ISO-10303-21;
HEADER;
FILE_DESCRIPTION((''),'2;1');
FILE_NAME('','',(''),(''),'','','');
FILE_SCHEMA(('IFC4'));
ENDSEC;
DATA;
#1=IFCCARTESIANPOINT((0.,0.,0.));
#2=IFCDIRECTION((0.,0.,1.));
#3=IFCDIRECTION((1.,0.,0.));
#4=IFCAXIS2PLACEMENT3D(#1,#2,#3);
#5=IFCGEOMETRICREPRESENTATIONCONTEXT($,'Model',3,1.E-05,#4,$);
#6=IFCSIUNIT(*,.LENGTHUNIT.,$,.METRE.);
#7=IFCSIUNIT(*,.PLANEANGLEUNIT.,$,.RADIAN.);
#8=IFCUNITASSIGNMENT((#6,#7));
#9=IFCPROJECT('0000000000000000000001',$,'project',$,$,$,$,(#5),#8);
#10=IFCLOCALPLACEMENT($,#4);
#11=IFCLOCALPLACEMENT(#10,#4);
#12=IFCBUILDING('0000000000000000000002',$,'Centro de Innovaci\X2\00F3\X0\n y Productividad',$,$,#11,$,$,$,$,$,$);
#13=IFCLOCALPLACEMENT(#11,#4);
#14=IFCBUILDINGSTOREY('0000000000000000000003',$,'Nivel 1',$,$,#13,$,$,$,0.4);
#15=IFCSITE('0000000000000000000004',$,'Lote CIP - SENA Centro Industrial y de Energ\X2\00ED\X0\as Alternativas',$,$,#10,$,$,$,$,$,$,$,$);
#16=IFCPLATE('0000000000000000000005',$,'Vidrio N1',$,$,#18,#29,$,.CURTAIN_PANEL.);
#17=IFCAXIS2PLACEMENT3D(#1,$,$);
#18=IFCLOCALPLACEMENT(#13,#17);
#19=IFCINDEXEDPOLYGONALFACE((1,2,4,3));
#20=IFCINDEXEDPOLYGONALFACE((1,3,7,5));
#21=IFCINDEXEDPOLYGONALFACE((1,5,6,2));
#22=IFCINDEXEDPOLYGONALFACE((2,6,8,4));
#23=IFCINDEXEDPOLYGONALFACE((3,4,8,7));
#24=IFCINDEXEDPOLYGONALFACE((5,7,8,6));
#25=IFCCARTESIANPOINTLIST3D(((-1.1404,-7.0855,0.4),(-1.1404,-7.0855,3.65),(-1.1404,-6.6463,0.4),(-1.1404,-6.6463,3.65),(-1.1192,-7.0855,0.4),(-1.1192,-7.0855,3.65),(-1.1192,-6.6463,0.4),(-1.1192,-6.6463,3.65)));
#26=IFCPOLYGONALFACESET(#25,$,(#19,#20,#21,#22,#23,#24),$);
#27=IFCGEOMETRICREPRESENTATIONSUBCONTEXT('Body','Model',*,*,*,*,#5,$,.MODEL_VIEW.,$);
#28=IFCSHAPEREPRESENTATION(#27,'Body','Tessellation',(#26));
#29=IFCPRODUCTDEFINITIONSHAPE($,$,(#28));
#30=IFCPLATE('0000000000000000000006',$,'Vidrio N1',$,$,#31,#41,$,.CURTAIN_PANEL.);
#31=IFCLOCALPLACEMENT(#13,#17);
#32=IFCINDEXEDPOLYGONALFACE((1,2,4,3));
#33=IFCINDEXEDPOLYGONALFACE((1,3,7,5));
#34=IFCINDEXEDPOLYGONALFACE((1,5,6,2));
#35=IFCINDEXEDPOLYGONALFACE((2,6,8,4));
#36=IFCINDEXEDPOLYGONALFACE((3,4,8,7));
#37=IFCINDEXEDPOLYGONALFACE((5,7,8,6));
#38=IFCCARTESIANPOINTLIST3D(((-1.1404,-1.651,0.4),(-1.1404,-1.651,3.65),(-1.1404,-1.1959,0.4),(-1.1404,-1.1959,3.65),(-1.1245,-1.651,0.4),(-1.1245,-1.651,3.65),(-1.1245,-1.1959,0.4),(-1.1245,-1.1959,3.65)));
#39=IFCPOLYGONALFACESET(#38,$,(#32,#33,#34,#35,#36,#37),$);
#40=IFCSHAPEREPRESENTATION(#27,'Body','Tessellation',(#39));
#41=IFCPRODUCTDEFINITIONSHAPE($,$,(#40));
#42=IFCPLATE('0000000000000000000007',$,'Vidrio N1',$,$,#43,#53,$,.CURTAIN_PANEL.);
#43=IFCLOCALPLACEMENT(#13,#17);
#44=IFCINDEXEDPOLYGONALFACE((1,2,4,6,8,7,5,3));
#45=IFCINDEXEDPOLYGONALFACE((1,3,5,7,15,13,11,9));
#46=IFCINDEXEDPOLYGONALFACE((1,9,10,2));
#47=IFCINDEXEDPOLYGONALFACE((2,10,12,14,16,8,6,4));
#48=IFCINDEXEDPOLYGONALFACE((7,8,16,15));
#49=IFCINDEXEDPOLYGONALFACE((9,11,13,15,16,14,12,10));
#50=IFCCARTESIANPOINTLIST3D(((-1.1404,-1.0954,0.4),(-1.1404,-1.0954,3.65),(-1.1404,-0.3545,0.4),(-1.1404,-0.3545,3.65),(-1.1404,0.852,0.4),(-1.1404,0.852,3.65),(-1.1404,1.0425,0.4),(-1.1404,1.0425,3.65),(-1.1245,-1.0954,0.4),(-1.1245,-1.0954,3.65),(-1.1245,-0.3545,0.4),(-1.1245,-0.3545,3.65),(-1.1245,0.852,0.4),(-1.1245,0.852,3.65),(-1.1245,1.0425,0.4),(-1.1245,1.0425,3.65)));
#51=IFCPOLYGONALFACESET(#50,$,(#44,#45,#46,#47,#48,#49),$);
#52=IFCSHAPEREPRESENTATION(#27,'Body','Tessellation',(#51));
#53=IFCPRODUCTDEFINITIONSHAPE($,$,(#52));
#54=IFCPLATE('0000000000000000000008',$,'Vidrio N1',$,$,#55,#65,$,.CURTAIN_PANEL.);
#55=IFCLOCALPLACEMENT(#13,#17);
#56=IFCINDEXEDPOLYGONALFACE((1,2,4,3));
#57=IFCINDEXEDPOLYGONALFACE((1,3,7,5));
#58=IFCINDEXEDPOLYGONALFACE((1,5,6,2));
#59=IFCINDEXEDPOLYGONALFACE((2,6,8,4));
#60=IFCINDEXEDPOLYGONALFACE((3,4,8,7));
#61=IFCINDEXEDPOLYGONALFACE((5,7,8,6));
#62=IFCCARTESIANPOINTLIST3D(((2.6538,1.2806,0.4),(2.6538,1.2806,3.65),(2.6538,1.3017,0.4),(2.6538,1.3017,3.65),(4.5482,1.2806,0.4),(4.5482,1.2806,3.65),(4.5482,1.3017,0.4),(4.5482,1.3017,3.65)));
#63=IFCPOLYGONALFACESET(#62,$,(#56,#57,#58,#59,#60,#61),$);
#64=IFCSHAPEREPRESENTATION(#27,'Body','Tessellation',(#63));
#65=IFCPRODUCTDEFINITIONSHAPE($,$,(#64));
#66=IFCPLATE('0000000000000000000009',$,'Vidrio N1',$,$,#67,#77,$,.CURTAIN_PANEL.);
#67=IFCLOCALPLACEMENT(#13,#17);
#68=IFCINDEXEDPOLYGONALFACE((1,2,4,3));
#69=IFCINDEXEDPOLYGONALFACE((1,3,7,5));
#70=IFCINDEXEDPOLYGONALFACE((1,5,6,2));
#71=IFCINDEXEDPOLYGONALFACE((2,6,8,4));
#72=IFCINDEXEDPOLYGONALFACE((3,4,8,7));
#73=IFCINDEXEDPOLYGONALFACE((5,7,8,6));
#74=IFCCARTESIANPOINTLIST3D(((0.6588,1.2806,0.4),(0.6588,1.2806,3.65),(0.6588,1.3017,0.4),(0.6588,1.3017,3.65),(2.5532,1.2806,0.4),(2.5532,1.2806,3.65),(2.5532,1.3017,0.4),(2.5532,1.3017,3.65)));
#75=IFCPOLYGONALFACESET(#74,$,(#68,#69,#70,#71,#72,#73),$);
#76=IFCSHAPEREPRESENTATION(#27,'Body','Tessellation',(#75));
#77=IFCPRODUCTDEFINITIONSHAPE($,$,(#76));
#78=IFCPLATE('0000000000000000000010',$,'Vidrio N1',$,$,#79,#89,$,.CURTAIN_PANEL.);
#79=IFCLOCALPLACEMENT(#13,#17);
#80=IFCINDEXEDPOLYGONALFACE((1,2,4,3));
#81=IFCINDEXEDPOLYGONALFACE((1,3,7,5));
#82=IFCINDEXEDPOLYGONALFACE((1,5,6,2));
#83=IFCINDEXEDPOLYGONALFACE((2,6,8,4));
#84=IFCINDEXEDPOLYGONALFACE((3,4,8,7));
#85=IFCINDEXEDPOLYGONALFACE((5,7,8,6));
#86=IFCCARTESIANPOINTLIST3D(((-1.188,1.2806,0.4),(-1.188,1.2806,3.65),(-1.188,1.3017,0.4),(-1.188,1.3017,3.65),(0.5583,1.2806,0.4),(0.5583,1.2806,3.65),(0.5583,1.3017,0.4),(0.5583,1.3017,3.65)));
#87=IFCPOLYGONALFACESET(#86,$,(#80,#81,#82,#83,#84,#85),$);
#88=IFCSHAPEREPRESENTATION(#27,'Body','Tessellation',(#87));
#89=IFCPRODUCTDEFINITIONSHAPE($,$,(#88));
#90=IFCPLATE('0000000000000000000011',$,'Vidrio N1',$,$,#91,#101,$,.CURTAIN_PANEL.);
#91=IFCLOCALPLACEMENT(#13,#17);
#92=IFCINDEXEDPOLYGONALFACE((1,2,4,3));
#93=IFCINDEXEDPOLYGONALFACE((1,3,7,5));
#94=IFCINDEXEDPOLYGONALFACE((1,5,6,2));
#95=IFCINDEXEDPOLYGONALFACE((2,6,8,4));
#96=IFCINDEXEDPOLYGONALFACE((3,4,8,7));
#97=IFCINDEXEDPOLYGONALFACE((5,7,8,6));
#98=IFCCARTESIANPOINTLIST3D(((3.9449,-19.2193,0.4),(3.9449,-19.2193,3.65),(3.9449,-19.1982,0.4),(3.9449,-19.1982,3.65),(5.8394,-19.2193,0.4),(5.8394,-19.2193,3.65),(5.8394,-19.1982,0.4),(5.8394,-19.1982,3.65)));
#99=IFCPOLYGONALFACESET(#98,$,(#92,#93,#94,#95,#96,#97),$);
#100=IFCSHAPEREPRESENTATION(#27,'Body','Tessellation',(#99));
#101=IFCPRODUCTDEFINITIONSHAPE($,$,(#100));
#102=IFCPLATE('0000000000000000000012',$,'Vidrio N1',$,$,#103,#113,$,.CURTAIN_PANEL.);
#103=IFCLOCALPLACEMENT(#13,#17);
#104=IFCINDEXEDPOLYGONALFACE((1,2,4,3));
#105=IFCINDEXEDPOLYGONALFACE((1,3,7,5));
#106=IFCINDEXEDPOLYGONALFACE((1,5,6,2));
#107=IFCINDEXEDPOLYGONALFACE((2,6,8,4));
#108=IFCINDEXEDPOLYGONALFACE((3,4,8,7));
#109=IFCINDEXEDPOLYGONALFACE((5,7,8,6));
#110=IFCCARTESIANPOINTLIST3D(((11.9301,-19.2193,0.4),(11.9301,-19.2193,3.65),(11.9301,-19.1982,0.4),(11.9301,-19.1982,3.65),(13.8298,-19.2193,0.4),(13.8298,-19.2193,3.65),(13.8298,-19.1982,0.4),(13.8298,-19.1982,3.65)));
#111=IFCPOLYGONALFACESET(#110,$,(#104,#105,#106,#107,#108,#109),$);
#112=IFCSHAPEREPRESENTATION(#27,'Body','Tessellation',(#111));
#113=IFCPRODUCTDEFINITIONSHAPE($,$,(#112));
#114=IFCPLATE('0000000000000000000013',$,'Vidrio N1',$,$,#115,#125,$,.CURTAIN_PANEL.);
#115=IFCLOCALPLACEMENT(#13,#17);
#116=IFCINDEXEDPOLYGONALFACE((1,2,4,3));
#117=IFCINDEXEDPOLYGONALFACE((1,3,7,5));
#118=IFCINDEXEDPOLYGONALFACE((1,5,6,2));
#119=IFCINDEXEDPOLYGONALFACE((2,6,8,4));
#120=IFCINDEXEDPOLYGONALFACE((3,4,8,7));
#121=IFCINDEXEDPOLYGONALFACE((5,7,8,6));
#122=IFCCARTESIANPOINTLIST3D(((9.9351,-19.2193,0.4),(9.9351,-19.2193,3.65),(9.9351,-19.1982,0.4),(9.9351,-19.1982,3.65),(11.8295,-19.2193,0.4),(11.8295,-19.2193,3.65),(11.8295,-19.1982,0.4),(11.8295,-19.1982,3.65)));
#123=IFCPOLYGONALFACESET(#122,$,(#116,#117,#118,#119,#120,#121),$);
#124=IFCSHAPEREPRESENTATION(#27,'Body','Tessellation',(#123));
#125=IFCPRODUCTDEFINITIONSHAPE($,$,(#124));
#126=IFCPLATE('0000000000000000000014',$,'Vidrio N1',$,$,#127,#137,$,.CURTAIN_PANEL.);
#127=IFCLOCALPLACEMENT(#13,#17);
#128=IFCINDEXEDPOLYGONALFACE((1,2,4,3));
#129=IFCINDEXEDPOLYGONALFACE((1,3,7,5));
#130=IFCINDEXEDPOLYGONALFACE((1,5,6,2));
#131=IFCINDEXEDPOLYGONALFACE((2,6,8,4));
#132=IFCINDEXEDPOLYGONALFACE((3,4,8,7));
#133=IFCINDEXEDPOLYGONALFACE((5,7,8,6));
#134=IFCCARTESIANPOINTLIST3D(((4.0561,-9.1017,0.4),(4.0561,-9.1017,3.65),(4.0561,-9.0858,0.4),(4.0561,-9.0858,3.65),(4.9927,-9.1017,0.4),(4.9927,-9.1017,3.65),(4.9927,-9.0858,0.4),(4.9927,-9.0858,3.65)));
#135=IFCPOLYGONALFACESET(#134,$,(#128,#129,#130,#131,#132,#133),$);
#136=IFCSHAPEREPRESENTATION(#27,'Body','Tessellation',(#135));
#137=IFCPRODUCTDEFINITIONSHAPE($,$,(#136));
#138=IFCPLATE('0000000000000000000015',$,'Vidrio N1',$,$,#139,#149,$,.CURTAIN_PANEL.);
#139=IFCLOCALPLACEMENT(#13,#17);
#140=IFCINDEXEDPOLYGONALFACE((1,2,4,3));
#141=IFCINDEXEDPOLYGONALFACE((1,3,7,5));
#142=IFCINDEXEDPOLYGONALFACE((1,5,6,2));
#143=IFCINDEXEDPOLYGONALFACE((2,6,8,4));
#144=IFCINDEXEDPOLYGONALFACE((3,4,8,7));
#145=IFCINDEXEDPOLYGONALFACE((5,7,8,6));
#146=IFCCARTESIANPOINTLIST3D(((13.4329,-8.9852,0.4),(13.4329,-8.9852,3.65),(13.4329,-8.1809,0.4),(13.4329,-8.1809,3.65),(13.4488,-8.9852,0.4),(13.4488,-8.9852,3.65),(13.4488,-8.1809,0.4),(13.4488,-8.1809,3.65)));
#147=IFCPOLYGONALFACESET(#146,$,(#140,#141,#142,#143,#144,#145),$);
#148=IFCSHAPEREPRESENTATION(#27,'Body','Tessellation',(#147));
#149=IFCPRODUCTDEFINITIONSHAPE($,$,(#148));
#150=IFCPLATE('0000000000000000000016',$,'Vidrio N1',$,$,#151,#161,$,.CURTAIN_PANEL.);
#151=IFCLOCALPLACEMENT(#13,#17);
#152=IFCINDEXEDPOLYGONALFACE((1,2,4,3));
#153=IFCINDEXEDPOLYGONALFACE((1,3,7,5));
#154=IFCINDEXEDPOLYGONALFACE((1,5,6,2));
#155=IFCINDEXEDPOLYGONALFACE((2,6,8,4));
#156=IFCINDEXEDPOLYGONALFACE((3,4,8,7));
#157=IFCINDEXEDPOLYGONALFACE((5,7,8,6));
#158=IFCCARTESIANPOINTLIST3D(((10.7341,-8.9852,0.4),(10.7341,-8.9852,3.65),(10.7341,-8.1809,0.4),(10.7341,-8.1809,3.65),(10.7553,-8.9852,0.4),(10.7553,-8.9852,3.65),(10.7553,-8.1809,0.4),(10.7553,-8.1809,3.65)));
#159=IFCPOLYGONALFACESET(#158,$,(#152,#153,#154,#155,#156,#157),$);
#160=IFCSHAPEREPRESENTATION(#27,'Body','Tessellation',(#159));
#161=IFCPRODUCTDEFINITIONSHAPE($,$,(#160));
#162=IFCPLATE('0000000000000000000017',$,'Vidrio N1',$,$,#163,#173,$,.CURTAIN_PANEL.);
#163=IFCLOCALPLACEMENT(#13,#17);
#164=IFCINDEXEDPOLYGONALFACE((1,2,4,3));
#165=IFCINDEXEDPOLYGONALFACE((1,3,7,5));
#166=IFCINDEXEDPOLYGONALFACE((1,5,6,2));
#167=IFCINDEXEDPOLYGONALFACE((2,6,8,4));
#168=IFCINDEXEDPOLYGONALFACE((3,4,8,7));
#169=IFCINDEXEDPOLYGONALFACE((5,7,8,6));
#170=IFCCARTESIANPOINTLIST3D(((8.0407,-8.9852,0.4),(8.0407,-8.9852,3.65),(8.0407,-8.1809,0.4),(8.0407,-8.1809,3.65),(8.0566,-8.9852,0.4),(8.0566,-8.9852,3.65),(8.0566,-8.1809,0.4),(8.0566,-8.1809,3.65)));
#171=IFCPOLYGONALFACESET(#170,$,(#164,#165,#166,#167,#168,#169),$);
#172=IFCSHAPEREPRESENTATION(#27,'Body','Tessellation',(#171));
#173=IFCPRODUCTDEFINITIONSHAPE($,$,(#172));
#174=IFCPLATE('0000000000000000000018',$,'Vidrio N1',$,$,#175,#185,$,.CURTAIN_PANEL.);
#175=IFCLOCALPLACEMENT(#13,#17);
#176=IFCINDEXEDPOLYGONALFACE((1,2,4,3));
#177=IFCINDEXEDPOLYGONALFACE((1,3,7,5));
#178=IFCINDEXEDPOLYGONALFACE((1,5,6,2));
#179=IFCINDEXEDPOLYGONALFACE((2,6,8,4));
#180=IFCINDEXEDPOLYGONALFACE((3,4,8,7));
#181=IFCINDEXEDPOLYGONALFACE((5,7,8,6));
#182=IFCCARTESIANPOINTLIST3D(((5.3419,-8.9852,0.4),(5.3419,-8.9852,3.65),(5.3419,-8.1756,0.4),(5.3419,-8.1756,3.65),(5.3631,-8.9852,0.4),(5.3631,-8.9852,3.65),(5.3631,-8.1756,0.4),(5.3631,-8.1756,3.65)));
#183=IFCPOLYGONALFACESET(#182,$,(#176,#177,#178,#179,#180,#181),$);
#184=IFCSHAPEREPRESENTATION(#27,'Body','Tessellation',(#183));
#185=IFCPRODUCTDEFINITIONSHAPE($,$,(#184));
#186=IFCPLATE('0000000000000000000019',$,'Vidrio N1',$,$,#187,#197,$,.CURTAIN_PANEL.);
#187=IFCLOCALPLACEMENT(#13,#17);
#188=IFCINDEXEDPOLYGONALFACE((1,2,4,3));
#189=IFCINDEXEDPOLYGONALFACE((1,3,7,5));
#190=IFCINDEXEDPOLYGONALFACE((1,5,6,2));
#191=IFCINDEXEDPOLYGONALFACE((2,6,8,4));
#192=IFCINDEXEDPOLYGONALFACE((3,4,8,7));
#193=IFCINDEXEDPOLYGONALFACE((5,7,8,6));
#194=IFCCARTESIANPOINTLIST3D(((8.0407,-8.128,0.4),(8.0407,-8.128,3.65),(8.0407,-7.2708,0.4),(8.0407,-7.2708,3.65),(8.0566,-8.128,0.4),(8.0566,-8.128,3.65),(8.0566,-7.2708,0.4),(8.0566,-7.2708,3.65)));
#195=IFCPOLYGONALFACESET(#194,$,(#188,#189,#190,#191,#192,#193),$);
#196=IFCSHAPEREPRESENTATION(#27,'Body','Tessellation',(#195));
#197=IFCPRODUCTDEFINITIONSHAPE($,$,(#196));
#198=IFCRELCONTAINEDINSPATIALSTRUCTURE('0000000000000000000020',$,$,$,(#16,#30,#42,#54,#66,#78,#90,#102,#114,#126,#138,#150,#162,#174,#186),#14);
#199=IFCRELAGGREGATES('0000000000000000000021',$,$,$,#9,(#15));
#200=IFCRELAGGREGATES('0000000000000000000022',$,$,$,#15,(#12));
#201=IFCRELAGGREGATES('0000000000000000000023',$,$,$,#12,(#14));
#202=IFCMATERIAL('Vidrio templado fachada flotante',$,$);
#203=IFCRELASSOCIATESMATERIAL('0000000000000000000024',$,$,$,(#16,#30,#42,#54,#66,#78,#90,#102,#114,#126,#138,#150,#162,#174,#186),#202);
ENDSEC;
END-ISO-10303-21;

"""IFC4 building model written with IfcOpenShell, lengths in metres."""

from ifc_helpers import new_model, si_unit, frame, origin_with_axes, place, context, subcontext, project, spatial, polyline, outline, extrude, material, element, save


model = new_model("IFC4")

# Units and contexts
model_context = context("Model", 3, precision=1e-05, world=origin_with_axes())
body_context = subcontext(model_context, "Body", "Model", "MODEL_VIEW")
ifc_project = project(units=[si_unit("LENGTHUNIT", "METRE"), si_unit("PLANEANGLEUNIT", "RADIAN")], contexts=[model_context])

# Site, building, storey
site_placement = place(None, origin_with_axes())
site = spatial("IfcSite", under=ifc_project, at=site_placement, Name="Lote CIP - SENA Centro Industrial y de Energías Alternativas")
building_placement = place(site_placement, origin_with_axes())
building = spatial("IfcBuilding", under=site, at=building_placement, Name="Centro de Innovación y Productividad")
storey_placement = place(building_placement, origin_with_axes())
storey = spatial("IfcBuildingStorey", under=building, at=storey_placement, Name="Nivel 1", Elevation=0.4)

# Plates
ifc_material = material(Name="Vidrio templado fachada flotante")
plate_1_placement = place(storey_placement, origin_with_axes())
element("IfcPlate", 1, at=plate_1_placement, inside=storey, material=ifc_material, Name="Vidrio N1", PredefinedType="CURTAIN_PANEL", context=body_context, shape_type="SweptSolid", body=[
    extrude(outline(polyline([(-1.1192, -6.6463), (-1.1192, -7.0855), (-1.1404, -7.0855), (-1.1404, -6.6463), (-1.1192, -6.6463)])), frame((0.0, 0.0, 0.4)), (0.0, 0.0, 1.0), 3.25),
])
plate_2_placement = place(storey_placement, origin_with_axes())
element("IfcPlate", 2, at=plate_2_placement, inside=storey, material=ifc_material, Name="Vidrio N1", PredefinedType="CURTAIN_PANEL", context=body_context, shape_type="SweptSolid", body=[
    extrude(outline(polyline([(-1.1245, -1.1959), (-1.1245, -1.651), (-1.1404, -1.651), (-1.1404, -1.1959), (-1.1245, -1.1959)])), frame((0.0, 0.0, 0.4)), (0.0, 0.0, 1.0), 3.25),
])
plate_3_placement = place(storey_placement, origin_with_axes())
element("IfcPlate", 3, at=plate_3_placement, inside=storey, material=ifc_material, Name="Vidrio N1", PredefinedType="CURTAIN_PANEL", context=body_context, shape_type="SweptSolid", body=[
    extrude(outline(polyline([(-1.1245, 1.0425), (-1.1245, 0.852), (-1.1245, -0.3545), (-1.1245, -1.0954), (-1.1404, -1.0954), (-1.1404, -0.3545), (-1.1404, 0.852), (-1.1404, 1.0425), (-1.1245, 1.0425)])), frame((0.0, 0.0, 0.4)), (0.0, 0.0, 1.0), 3.25),
])
plate_4_placement = place(storey_placement, origin_with_axes())
element("IfcPlate", 4, at=plate_4_placement, inside=storey, material=ifc_material, Name="Vidrio N1", PredefinedType="CURTAIN_PANEL", context=body_context, shape_type="SweptSolid", body=[
    extrude(outline(polyline([(2.6538, 1.2806), (2.6538, 1.3017), (4.5482, 1.3017), (4.5482, 1.2806), (2.6538, 1.2806)])), frame((0.0, 0.0, 0.4)), (0.0, 0.0, 1.0), 3.25),
])
plate_5_placement = place(storey_placement, origin_with_axes())
element("IfcPlate", 5, at=plate_5_placement, inside=storey, material=ifc_material, Name="Vidrio N1", PredefinedType="CURTAIN_PANEL", context=body_context, shape_type="SweptSolid", body=[
    extrude(outline(polyline([(2.5532, 1.3017), (2.5532, 1.2806), (0.6588, 1.2806), (0.6588, 1.3017), (2.5532, 1.3017)])), frame((0.0, 0.0, 0.4)), (0.0, 0.0, 1.0), 3.25),
])
plate_6_placement = place(storey_placement, origin_with_axes())
element("IfcPlate", 6, at=plate_6_placement, inside=storey, material=ifc_material, Name="Vidrio N1", PredefinedType="CURTAIN_PANEL", context=body_context, shape_type="SweptSolid", body=[
    extrude(outline(polyline([(0.5583, 1.2806), (-1.188, 1.2806), (-1.188, 1.3017), (0.5583, 1.3017), (0.5583, 1.2806)])), frame((0.0, 0.0, 0.4)), (0.0, 0.0, 1.0), 3.25),
])
plate_7_placement = place(storey_placement, origin_with_axes())
element("IfcPlate", 7, at=plate_7_placement, inside=storey, material=ifc_material, Name="Vidrio N1", PredefinedType="CURTAIN_PANEL", context=body_context, shape_type="SweptSolid", body=[
    extrude(outline(polyline([(3.9449, -19.2193), (3.9449, -19.1982), (5.8394, -19.1982), (5.8394, -19.2193), (3.9449, -19.2193)])), frame((0.0, 0.0, 0.4)), (0.0, 0.0, 1.0), 3.25),
])
plate_8_placement = place(storey_placement, origin_with_axes())
element("IfcPlate", 8, at=plate_8_placement, inside=storey, material=ifc_material, Name="Vidrio N1", PredefinedType="CURTAIN_PANEL", context=body_context, shape_type="SweptSolid", body=[
    extrude(outline(polyline([(13.8298, -19.2193), (11.9301, -19.2193), (11.9301, -19.1982), (13.8298, -19.1982), (13.8298, -19.2193)])), frame((0.0, 0.0, 0.4)), (0.0, 0.0, 1.0), 3.25),
])
plate_9_placement = place(storey_placement, origin_with_axes())
element("IfcPlate", 9, at=plate_9_placement, inside=storey, material=ifc_material, Name="Vidrio N1", PredefinedType="CURTAIN_PANEL", context=body_context, shape_type="SweptSolid", body=[
    extrude(outline(polyline([(11.8295, -19.1982), (11.8295, -19.2193), (9.9351, -19.2193), (9.9351, -19.1982), (11.8295, -19.1982)])), frame((0.0, 0.0, 0.4)), (0.0, 0.0, 1.0), 3.25),
])
plate_10_placement = place(storey_placement, origin_with_axes())
element("IfcPlate", 10, at=plate_10_placement, inside=storey, material=ifc_material, Name="Vidrio N1", PredefinedType="CURTAIN_PANEL", context=body_context, shape_type="SweptSolid", body=[
    extrude(outline(polyline([(4.9927, -9.0858), (4.9927, -9.1017), (4.0561, -9.1017), (4.0561, -9.0858), (4.9927, -9.0858)])), frame((0.0, 0.0, 0.4)), (0.0, 0.0, 1.0), 3.25),
])
plate_11_placement = place(storey_placement, origin_with_axes())
element("IfcPlate", 11, at=plate_11_placement, inside=storey, material=ifc_material, Name="Vidrio N1", PredefinedType="CURTAIN_PANEL", context=body_context, shape_type="SweptSolid", body=[
    extrude(outline(polyline([(13.4488, -8.9853), (13.4329, -8.9853), (13.4329, -8.1809), (13.4488, -8.1809), (13.4488, -8.9853)])), frame((0.0, 0.0, 0.4)), (0.0, 0.0, 1.0), 3.25),
])
plate_12_placement = place(storey_placement, origin_with_axes())
element("IfcPlate", 12, at=plate_12_placement, inside=storey, material=ifc_material, Name="Vidrio N1", PredefinedType="CURTAIN_PANEL", context=body_context, shape_type="SweptSolid", body=[
    extrude(outline(polyline([(10.7553, -8.1809), (10.7553, -8.9853), (10.7341, -8.9853), (10.7341, -8.1809), (10.7553, -8.1809)])), frame((0.0, 0.0, 0.4)), (0.0, 0.0, 1.0), 3.25),
])
plate_13_placement = place(storey_placement, origin_with_axes())
element("IfcPlate", 13, at=plate_13_placement, inside=storey, material=ifc_material, Name="Vidrio N1", PredefinedType="CURTAIN_PANEL", context=body_context, shape_type="SweptSolid", body=[
    extrude(outline(polyline([(8.0566, -8.9853), (8.0407, -8.9853), (8.0407, -8.1809), (8.0566, -8.1809), (8.0566, -8.9853)])), frame((0.0, 0.0, 0.4)), (0.0, 0.0, 1.0), 3.25),
])
plate_14_placement = place(storey_placement, origin_with_axes())
element("IfcPlate", 14, at=plate_14_placement, inside=storey, material=ifc_material, Name="Vidrio N1", PredefinedType="CURTAIN_PANEL", context=body_context, shape_type="SweptSolid", body=[
    extrude(outline(polyline([(5.3631, -8.1756), (5.3631, -8.9853), (5.3419, -8.9853), (5.3419, -8.1756), (5.3631, -8.1756)])), frame((0.0, 0.0, 0.4)), (0.0, 0.0, 1.0), 3.25),
])
plate_15_placement = place(storey_placement, origin_with_axes())
element("IfcPlate", 15, at=plate_15_placement, inside=storey, material=ifc_material, Name="Vidrio N1", PredefinedType="CURTAIN_PANEL", context=body_context, shape_type="SweptSolid", body=[
    extrude(outline(polyline([(8.0407, -8.128), (8.0407, -7.2708), (8.0566, -7.2708), (8.0566, -8.128), (8.0407, -8.128)])), frame((0.0, 0.0, 0.4)), (0.0, 0.0, 1.0), 3.25),
])

save(model, "model.ifc")
